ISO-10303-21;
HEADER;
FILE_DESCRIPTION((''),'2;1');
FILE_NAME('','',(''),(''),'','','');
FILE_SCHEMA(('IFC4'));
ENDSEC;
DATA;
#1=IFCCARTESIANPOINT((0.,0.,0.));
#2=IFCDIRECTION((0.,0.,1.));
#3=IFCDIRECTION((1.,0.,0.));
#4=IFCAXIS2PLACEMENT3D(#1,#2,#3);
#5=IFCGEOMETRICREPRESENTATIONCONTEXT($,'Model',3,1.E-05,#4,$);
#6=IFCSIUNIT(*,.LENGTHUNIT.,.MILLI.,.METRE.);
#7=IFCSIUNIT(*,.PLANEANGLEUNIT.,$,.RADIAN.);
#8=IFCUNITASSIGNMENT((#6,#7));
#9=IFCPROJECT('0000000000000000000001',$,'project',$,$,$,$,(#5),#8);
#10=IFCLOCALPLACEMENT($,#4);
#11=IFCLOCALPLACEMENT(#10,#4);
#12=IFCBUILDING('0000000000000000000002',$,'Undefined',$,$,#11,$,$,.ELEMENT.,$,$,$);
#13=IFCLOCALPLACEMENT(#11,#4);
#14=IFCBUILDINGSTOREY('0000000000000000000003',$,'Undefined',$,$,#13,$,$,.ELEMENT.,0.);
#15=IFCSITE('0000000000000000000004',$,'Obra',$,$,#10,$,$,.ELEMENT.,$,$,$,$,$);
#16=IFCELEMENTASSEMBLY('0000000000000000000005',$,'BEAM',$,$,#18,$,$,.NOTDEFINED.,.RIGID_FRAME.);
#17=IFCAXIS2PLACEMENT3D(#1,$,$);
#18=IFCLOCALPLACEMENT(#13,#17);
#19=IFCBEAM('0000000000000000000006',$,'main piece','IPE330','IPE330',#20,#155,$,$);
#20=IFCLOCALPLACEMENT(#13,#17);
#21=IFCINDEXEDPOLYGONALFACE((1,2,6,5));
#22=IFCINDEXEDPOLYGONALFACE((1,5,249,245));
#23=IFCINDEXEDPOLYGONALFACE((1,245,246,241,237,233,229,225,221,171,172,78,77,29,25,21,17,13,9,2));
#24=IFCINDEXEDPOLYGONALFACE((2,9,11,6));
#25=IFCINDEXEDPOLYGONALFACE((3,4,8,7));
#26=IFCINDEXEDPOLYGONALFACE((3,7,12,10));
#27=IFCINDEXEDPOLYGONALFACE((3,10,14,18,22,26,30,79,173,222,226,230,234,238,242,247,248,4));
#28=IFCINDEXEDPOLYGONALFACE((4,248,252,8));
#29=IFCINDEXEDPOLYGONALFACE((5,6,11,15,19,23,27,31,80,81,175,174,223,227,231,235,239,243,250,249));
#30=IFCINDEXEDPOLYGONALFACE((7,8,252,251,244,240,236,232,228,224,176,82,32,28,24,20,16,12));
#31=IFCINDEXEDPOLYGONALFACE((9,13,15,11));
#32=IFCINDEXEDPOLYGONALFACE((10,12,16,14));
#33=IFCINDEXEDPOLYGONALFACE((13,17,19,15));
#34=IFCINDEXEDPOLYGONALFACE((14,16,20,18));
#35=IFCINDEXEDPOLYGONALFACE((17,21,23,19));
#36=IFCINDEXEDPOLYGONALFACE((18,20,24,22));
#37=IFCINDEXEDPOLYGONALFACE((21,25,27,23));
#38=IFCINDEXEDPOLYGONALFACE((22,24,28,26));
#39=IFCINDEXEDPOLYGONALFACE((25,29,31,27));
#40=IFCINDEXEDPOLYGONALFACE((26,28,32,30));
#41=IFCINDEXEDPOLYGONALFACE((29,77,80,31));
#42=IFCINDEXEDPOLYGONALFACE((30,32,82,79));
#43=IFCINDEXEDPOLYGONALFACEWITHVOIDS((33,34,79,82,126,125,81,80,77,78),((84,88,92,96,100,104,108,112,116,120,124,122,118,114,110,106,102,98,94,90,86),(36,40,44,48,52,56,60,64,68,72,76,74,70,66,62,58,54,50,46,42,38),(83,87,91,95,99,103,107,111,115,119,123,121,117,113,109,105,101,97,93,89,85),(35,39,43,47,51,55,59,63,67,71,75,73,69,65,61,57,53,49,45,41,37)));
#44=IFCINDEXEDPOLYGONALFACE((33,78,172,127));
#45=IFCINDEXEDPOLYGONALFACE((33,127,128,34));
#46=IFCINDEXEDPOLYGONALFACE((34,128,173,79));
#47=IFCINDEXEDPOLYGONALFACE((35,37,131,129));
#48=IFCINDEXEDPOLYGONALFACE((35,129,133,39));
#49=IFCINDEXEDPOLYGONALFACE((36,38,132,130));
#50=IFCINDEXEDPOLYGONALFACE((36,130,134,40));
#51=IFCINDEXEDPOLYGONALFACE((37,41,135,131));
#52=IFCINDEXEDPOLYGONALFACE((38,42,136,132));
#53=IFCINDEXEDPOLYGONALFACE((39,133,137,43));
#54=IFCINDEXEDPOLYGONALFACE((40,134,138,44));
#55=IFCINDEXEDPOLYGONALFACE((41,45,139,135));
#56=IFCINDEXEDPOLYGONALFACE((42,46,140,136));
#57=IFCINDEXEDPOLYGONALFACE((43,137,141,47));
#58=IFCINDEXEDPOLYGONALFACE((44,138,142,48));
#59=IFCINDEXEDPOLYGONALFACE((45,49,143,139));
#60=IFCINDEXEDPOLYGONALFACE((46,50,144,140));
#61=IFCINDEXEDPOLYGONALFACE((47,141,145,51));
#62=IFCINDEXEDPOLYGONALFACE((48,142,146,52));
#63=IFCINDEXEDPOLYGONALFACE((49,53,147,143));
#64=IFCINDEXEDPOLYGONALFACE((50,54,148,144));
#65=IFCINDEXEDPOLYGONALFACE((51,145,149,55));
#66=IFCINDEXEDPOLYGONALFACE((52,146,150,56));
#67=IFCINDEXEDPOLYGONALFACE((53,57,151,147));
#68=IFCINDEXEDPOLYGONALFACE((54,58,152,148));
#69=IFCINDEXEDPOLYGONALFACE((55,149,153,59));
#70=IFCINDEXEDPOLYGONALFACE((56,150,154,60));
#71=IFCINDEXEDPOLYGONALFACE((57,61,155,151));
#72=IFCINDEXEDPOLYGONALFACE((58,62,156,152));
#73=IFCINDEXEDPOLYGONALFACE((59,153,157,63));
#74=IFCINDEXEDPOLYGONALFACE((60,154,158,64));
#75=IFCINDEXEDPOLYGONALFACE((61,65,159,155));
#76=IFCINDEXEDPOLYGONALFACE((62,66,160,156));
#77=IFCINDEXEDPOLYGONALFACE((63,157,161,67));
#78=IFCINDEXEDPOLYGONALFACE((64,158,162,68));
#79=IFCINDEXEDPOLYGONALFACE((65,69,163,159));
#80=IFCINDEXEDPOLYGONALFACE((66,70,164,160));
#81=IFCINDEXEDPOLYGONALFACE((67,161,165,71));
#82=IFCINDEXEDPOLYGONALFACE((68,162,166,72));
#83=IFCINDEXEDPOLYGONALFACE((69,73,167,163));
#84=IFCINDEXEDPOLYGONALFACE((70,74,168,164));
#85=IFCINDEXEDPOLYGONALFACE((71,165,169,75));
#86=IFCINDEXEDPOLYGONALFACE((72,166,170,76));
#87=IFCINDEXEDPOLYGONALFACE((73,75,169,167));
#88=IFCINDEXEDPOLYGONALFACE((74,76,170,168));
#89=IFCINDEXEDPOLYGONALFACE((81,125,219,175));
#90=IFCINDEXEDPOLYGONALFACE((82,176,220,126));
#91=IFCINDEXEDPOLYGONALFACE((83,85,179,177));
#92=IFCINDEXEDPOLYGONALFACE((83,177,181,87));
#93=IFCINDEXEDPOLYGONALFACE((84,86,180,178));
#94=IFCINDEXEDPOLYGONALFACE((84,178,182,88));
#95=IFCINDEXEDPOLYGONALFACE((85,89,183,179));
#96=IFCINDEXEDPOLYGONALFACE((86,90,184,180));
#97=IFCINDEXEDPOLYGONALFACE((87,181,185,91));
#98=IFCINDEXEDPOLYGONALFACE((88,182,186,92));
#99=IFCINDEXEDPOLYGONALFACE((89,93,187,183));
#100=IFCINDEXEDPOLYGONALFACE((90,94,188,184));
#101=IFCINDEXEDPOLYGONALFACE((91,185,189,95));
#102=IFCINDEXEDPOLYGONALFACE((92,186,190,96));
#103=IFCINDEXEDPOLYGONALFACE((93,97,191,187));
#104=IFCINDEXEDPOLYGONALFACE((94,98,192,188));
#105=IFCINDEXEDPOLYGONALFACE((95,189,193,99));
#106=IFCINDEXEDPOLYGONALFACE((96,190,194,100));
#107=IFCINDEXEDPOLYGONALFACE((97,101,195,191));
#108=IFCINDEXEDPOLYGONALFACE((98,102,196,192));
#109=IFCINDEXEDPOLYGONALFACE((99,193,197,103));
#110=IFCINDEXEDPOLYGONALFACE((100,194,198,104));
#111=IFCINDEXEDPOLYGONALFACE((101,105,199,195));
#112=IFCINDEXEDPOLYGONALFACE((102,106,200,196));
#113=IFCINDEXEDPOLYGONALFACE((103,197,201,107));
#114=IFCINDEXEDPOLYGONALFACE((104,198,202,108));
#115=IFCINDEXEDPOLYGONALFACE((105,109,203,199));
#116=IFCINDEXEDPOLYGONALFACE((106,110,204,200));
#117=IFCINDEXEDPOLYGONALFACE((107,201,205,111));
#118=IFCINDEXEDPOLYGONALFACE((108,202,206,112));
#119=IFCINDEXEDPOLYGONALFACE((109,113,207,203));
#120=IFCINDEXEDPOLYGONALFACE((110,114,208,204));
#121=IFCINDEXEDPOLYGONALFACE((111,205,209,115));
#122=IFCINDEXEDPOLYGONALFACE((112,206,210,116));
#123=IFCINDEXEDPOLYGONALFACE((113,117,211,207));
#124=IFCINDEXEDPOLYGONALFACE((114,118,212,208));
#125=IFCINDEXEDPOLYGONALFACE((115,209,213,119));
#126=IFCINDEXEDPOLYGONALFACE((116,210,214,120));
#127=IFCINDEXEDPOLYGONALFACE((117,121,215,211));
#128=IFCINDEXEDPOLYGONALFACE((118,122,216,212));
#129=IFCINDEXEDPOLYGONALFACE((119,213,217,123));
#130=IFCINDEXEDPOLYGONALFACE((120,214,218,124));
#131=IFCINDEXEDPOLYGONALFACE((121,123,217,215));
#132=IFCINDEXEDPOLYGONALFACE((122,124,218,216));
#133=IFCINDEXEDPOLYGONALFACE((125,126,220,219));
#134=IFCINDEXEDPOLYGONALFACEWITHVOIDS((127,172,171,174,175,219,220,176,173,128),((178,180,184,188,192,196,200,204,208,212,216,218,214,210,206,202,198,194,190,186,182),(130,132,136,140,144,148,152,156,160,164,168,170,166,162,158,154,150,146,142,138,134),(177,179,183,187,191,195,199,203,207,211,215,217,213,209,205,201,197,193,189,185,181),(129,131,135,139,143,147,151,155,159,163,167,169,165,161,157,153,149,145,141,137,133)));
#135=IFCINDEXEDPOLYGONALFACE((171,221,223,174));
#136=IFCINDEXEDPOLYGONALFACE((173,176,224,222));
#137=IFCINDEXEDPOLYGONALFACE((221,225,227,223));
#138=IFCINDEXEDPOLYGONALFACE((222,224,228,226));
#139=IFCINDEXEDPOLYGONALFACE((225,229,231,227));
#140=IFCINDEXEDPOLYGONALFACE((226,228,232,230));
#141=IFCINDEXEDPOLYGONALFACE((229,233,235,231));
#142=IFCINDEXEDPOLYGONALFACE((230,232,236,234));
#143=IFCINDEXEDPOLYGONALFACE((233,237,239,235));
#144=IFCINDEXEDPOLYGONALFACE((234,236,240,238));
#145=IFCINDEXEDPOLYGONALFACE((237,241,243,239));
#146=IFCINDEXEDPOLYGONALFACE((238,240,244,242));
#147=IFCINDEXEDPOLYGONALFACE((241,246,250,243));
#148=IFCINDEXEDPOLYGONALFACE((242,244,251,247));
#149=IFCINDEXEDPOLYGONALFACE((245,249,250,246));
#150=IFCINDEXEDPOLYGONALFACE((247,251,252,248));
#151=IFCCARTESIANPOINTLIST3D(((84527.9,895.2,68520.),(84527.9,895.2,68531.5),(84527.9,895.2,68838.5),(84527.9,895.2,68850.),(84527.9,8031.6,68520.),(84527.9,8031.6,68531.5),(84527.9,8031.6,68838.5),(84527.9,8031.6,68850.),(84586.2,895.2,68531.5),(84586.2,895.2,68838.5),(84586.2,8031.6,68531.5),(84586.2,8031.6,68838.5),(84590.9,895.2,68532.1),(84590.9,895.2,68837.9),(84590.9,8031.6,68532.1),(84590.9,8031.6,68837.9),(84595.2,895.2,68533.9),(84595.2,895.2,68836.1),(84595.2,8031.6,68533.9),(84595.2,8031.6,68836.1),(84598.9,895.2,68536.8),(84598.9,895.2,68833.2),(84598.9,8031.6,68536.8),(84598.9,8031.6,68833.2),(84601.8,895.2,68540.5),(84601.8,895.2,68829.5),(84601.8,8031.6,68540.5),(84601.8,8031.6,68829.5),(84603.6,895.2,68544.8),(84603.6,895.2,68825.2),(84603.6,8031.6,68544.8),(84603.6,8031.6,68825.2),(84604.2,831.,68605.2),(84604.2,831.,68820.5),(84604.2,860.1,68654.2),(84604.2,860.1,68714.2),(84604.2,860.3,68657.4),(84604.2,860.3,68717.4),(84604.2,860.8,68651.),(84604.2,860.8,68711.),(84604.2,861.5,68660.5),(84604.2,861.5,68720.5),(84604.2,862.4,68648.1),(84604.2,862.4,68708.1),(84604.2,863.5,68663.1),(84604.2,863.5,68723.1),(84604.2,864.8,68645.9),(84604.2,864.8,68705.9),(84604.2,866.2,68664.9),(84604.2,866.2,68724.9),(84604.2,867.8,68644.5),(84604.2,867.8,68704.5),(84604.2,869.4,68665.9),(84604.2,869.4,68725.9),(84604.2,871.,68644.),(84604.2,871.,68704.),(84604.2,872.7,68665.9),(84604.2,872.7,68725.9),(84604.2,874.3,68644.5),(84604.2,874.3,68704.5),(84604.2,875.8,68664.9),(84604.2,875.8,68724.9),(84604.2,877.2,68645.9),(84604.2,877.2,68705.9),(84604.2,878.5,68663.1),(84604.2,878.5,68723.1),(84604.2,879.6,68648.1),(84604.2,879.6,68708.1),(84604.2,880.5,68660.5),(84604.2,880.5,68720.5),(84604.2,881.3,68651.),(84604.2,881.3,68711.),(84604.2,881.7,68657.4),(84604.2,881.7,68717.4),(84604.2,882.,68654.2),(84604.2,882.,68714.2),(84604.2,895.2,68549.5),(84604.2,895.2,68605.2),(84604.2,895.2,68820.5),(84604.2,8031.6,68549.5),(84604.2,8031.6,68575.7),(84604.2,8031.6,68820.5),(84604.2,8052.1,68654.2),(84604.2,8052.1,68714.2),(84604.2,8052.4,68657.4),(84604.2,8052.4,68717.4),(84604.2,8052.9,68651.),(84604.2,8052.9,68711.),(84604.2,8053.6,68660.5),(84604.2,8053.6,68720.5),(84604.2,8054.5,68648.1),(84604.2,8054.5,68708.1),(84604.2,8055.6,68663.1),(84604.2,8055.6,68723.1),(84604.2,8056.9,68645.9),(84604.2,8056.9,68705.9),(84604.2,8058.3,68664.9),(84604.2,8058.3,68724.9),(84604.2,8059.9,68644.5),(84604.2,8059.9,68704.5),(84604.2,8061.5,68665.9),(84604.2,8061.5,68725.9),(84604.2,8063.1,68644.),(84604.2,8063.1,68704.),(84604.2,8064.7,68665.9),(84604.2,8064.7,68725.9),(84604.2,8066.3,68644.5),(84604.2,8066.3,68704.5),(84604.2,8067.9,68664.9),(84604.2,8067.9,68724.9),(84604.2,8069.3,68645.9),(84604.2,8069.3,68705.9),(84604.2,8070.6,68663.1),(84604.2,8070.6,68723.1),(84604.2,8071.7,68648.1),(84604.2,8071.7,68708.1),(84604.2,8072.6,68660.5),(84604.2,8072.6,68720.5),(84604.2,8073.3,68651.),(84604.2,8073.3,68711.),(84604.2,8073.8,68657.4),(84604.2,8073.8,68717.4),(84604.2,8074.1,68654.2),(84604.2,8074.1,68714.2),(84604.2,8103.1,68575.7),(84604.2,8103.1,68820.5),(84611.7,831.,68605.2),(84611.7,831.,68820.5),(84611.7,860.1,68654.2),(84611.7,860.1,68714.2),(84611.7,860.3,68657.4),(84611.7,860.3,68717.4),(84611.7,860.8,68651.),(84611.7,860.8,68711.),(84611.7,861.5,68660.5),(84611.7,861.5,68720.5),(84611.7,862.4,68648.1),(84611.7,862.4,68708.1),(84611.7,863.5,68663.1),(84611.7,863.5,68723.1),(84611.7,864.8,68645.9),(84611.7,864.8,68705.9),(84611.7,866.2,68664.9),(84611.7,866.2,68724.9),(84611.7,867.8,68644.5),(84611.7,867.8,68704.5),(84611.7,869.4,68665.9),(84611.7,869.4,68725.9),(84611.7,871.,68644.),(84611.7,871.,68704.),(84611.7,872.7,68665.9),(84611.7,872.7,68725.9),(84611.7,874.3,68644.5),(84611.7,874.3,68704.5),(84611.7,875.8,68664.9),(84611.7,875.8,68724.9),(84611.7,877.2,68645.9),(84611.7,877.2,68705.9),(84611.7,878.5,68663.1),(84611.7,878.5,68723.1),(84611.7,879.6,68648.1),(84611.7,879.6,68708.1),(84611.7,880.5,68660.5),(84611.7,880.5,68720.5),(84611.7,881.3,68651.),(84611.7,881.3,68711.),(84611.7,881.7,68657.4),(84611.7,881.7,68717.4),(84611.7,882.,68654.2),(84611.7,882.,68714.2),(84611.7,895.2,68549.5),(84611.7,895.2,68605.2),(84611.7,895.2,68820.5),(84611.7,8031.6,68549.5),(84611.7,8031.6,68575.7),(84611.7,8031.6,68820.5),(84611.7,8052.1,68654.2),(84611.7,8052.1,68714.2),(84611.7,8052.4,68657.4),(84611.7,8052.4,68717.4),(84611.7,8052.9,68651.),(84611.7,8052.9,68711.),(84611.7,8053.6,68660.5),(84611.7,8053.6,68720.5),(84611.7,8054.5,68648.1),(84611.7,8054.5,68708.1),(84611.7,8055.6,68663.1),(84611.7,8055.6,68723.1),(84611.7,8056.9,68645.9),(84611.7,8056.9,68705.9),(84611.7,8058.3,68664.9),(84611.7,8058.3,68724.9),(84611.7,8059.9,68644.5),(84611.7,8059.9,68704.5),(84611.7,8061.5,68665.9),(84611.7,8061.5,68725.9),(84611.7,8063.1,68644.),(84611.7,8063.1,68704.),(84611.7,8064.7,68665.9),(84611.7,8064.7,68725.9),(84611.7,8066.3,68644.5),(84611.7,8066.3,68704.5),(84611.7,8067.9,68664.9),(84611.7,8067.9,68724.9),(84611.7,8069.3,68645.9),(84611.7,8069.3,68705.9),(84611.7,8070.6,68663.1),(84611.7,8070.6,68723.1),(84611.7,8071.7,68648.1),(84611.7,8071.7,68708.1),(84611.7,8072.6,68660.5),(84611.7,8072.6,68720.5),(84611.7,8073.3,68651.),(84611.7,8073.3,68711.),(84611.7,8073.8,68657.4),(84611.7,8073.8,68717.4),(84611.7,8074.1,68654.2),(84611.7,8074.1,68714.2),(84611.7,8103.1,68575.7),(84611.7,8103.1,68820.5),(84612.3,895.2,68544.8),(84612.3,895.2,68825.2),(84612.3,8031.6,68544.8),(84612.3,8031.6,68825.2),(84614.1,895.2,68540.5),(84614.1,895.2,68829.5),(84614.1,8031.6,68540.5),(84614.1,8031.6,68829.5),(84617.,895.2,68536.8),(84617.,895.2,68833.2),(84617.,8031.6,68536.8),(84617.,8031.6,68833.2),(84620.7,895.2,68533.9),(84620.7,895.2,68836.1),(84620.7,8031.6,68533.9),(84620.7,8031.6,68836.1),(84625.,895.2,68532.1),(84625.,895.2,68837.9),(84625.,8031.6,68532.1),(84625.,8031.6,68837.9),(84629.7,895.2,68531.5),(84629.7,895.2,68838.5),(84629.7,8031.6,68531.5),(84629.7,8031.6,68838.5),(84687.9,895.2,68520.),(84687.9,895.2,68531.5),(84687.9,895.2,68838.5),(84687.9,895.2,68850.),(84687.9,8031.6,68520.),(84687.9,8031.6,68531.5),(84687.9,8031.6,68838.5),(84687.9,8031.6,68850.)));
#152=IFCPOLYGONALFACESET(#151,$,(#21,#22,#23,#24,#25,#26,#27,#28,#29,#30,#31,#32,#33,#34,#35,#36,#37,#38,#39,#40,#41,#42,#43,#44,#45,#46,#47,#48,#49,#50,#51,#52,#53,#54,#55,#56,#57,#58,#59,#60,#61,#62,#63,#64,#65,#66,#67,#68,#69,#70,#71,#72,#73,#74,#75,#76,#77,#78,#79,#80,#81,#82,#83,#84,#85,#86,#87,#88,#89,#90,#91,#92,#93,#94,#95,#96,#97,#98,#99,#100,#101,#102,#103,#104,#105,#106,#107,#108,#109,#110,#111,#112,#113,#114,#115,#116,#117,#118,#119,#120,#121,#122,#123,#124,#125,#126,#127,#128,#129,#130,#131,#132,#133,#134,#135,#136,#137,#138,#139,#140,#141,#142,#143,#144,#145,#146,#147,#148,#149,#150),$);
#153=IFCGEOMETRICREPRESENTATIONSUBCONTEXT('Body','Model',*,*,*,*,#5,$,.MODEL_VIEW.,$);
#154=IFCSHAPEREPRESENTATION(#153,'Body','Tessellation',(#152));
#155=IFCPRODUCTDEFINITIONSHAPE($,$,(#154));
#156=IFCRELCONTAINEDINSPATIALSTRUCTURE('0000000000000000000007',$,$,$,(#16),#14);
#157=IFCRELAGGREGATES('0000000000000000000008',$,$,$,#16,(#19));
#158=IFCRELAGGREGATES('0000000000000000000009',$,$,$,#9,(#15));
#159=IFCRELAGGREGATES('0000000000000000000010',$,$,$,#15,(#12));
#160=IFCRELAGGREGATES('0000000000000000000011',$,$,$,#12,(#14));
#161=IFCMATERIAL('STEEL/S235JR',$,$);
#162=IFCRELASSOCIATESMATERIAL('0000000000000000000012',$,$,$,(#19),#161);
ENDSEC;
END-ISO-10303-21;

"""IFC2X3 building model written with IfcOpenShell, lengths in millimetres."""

from ifc_helpers import new_model, si_unit, frame, origin_with_axes, origin_2d_with_axis, place, context, subcontext, project, spatial, rectangle, circle, i_section, extrude, clip, halfspace, source, transform, mapped, material, element, aggregate, save


model = new_model("IFC2X3")

# Units and contexts
model_context = context("Model", 3, precision=1e-05, world=origin_with_axes())
body_context = subcontext(model_context, "Body", "Model", "MODEL_VIEW")
ifc_project = project(units=[si_unit("LENGTHUNIT", "METRE", prefix="MILLI"), si_unit("PLANEANGLEUNIT", "RADIAN")], contexts=[model_context])

# Site, building, storey
site_placement = place(None, origin_with_axes())
site = spatial("IfcSite", under=ifc_project, at=site_placement, Name="Obra", CompositionType="ELEMENT")
building_placement = place(site_placement, origin_with_axes())
building = spatial("IfcBuilding", under=site, at=building_placement, Name="Undefined", CompositionType="ELEMENT")
storey_placement = place(building_placement, origin_with_axes())
storey = spatial("IfcBuildingStorey", under=building, at=storey_placement, Name="Undefined", CompositionType="ELEMENT", Elevation=0.0)

# Shared definitions
ifc_material = material(Name="STEEL/S235JR")

# Element assembly, beam, openings
shared_shape_1 = source(origin_with_axes(), body_context, "Body", "SweptSolid", [
    extrude(circle(Radius=11.0, at=origin_2d_with_axis()), frame((0.0, -3.9, 0.0), z_axis=(0.0, 1.0, 0.0), x_axis=(1.0, 0.0, 0.0)), (0.0, 0.0, 1.0), 7.7),
])
assembly_1_placement = place(storey_placement, origin_with_axes())
assembly_1 = element("IfcElementAssembly", 1, at=assembly_1_placement, inside=storey, Name="BEAM", AssemblyPlace="NOTDEFINED", PredefinedType="RIGID_FRAME")
beam_1_placement = place(assembly_1_placement, frame((84607.9, 898.0, 68685.0), z_axis=(0.0, 0.0, 1.0), x_axis=(0.0, 1.0, 0.0)))
beam_1 = element("IfcBeam", 2, at=beam_1_placement, material=ifc_material, Name="main piece", Description="IPE330", ObjectType="IPE330", context=body_context, shape_type="Clipping", body=[
    clip(clip(extrude(i_section(OverallWidth=160.0, OverallDepth=330.0, WebThickness=7.5, FlangeThickness=11.5, FilletRadius=18.0, at=origin_2d_with_axis()), frame((7205.1, 0.0, 0.0), z_axis=(-1.0, 0.0, 0.0), x_axis=(0.0, -1.0, 0.0)), (0.0, 0.0, 1.0), 7272.1), halfspace(frame((7205.1, 0.0, -265.0), z_axis=(-1.0, 0.0, 0.0), x_axis=(0.0, 1.0, 0.0)), True)), halfspace(frame((-66.9, 0.0, -265.0), z_axis=(1.0, 0.0, 0.0), x_axis=(0.0, -1.0, 0.0)), True)),
])
opening_1_placement = place(assembly_1_placement, frame((84607.9, 898.0, 68685.0), z_axis=(0.0, 0.0, 1.0), x_axis=(0.0, 1.0, 0.0)))
element("IfcOpeningElement", 3, at=opening_1_placement, cuts=beam_1, ObjectType="Recess", context=body_context, shape_type="SweptSolid", body=[
    extrude(rectangle(XDim=56.7, YDim=83.5, at=origin_2d_with_axis()), frame((7175.4, 81.0, -137.7), z_axis=(0.0, -1.0, 0.0), x_axis=(0.0, 0.0, -1.0)), (0.0, 0.0, 1.0), 162.0),
])
opening_2_placement = place(assembly_1_placement, frame((84607.9, 898.0, 68685.0), z_axis=(0.0, 0.0, 1.0), x_axis=(0.0, 1.0, 0.0)))
element("IfcOpeningElement", 4, at=opening_2_placement, cuts=beam_1, ObjectType="Recess", context=body_context, shape_type="SweptSolid", body=[
    extrude(rectangle(XDim=30.5, YDim=83.5, at=origin_2d_with_axis()), frame((7175.4, 81.0, 150.8), z_axis=(0.0, -1.0, 0.0), x_axis=(0.0, 0.0, -1.0)), (0.0, 0.0, 1.0), 162.0),
])
opening_3_placement = place(assembly_1_placement, frame((84607.9, 898.0, 68685.0), z_axis=(0.0, 0.0, 1.0), x_axis=(0.0, 1.0, 0.0)))
element("IfcOpeningElement", 5, at=opening_3_placement, cuts=beam_1, ObjectType="Recess", context=body_context, shape_type="SweptSolid", body=[
    extrude(rectangle(XDim=76.2, YDim=86.2, at=origin_2d_with_axis()), frame((-40.8, -81.0, -122.9), z_axis=(0.0, 1.0, 0.0), x_axis=(-1.0, 0.0, 0.0)), (0.0, 0.0, 1.0), 162.0),
])
opening_4_placement = place(assembly_1_placement, frame((84607.9, 898.0, 68685.0), z_axis=(0.0, 0.0, 1.0), x_axis=(0.0, 1.0, 0.0)))
element("IfcOpeningElement", 6, at=opening_4_placement, cuts=beam_1, ObjectType="Recess", context=body_context, shape_type="SweptSolid", body=[
    extrude(rectangle(XDim=30.5, YDim=76.2, at=origin_2d_with_axis()), frame((-40.8, -81.0, 150.8), z_axis=(0.0, 1.0, 0.0), x_axis=(0.0, 0.0, -1.0)), (0.0, 0.0, 1.0), 162.0),
])
opening_5_placement = place(assembly_1_placement, frame((84607.9, 8103.1, 68850.0), z_axis=(0.0, -1.0, 0.0), x_axis=(0.0, 0.0, -1.0)))
element("IfcOpeningElement", 7, at=opening_5_placement, cuts=beam_1, ObjectType="Opening", context=body_context, shape_type="MappedRepresentation", body=[
    mapped(shared_shape_1, transform((135.0, 0.0, 40.0))),
    mapped(shared_shape_1, transform((195.0, 0.0, 40.0))),
])
opening_6_placement = place(assembly_1_placement, frame((84607.9, 831.0, 68850.0), z_axis=(0.0, 1.0, 0.0), x_axis=(0.0, 0.0, -1.0)))
element("IfcOpeningElement", 8, at=opening_6_placement, cuts=beam_1, ObjectType="Opening", context=body_context, shape_type="MappedRepresentation", body=[
    mapped(shared_shape_1, transform((135.0, 0.0, 40.0))),
    mapped(shared_shape_1, transform((195.0, 0.0, 40.0))),
])
aggregate(assembly_1, [beam_1])

save(model, "model.ifc")
